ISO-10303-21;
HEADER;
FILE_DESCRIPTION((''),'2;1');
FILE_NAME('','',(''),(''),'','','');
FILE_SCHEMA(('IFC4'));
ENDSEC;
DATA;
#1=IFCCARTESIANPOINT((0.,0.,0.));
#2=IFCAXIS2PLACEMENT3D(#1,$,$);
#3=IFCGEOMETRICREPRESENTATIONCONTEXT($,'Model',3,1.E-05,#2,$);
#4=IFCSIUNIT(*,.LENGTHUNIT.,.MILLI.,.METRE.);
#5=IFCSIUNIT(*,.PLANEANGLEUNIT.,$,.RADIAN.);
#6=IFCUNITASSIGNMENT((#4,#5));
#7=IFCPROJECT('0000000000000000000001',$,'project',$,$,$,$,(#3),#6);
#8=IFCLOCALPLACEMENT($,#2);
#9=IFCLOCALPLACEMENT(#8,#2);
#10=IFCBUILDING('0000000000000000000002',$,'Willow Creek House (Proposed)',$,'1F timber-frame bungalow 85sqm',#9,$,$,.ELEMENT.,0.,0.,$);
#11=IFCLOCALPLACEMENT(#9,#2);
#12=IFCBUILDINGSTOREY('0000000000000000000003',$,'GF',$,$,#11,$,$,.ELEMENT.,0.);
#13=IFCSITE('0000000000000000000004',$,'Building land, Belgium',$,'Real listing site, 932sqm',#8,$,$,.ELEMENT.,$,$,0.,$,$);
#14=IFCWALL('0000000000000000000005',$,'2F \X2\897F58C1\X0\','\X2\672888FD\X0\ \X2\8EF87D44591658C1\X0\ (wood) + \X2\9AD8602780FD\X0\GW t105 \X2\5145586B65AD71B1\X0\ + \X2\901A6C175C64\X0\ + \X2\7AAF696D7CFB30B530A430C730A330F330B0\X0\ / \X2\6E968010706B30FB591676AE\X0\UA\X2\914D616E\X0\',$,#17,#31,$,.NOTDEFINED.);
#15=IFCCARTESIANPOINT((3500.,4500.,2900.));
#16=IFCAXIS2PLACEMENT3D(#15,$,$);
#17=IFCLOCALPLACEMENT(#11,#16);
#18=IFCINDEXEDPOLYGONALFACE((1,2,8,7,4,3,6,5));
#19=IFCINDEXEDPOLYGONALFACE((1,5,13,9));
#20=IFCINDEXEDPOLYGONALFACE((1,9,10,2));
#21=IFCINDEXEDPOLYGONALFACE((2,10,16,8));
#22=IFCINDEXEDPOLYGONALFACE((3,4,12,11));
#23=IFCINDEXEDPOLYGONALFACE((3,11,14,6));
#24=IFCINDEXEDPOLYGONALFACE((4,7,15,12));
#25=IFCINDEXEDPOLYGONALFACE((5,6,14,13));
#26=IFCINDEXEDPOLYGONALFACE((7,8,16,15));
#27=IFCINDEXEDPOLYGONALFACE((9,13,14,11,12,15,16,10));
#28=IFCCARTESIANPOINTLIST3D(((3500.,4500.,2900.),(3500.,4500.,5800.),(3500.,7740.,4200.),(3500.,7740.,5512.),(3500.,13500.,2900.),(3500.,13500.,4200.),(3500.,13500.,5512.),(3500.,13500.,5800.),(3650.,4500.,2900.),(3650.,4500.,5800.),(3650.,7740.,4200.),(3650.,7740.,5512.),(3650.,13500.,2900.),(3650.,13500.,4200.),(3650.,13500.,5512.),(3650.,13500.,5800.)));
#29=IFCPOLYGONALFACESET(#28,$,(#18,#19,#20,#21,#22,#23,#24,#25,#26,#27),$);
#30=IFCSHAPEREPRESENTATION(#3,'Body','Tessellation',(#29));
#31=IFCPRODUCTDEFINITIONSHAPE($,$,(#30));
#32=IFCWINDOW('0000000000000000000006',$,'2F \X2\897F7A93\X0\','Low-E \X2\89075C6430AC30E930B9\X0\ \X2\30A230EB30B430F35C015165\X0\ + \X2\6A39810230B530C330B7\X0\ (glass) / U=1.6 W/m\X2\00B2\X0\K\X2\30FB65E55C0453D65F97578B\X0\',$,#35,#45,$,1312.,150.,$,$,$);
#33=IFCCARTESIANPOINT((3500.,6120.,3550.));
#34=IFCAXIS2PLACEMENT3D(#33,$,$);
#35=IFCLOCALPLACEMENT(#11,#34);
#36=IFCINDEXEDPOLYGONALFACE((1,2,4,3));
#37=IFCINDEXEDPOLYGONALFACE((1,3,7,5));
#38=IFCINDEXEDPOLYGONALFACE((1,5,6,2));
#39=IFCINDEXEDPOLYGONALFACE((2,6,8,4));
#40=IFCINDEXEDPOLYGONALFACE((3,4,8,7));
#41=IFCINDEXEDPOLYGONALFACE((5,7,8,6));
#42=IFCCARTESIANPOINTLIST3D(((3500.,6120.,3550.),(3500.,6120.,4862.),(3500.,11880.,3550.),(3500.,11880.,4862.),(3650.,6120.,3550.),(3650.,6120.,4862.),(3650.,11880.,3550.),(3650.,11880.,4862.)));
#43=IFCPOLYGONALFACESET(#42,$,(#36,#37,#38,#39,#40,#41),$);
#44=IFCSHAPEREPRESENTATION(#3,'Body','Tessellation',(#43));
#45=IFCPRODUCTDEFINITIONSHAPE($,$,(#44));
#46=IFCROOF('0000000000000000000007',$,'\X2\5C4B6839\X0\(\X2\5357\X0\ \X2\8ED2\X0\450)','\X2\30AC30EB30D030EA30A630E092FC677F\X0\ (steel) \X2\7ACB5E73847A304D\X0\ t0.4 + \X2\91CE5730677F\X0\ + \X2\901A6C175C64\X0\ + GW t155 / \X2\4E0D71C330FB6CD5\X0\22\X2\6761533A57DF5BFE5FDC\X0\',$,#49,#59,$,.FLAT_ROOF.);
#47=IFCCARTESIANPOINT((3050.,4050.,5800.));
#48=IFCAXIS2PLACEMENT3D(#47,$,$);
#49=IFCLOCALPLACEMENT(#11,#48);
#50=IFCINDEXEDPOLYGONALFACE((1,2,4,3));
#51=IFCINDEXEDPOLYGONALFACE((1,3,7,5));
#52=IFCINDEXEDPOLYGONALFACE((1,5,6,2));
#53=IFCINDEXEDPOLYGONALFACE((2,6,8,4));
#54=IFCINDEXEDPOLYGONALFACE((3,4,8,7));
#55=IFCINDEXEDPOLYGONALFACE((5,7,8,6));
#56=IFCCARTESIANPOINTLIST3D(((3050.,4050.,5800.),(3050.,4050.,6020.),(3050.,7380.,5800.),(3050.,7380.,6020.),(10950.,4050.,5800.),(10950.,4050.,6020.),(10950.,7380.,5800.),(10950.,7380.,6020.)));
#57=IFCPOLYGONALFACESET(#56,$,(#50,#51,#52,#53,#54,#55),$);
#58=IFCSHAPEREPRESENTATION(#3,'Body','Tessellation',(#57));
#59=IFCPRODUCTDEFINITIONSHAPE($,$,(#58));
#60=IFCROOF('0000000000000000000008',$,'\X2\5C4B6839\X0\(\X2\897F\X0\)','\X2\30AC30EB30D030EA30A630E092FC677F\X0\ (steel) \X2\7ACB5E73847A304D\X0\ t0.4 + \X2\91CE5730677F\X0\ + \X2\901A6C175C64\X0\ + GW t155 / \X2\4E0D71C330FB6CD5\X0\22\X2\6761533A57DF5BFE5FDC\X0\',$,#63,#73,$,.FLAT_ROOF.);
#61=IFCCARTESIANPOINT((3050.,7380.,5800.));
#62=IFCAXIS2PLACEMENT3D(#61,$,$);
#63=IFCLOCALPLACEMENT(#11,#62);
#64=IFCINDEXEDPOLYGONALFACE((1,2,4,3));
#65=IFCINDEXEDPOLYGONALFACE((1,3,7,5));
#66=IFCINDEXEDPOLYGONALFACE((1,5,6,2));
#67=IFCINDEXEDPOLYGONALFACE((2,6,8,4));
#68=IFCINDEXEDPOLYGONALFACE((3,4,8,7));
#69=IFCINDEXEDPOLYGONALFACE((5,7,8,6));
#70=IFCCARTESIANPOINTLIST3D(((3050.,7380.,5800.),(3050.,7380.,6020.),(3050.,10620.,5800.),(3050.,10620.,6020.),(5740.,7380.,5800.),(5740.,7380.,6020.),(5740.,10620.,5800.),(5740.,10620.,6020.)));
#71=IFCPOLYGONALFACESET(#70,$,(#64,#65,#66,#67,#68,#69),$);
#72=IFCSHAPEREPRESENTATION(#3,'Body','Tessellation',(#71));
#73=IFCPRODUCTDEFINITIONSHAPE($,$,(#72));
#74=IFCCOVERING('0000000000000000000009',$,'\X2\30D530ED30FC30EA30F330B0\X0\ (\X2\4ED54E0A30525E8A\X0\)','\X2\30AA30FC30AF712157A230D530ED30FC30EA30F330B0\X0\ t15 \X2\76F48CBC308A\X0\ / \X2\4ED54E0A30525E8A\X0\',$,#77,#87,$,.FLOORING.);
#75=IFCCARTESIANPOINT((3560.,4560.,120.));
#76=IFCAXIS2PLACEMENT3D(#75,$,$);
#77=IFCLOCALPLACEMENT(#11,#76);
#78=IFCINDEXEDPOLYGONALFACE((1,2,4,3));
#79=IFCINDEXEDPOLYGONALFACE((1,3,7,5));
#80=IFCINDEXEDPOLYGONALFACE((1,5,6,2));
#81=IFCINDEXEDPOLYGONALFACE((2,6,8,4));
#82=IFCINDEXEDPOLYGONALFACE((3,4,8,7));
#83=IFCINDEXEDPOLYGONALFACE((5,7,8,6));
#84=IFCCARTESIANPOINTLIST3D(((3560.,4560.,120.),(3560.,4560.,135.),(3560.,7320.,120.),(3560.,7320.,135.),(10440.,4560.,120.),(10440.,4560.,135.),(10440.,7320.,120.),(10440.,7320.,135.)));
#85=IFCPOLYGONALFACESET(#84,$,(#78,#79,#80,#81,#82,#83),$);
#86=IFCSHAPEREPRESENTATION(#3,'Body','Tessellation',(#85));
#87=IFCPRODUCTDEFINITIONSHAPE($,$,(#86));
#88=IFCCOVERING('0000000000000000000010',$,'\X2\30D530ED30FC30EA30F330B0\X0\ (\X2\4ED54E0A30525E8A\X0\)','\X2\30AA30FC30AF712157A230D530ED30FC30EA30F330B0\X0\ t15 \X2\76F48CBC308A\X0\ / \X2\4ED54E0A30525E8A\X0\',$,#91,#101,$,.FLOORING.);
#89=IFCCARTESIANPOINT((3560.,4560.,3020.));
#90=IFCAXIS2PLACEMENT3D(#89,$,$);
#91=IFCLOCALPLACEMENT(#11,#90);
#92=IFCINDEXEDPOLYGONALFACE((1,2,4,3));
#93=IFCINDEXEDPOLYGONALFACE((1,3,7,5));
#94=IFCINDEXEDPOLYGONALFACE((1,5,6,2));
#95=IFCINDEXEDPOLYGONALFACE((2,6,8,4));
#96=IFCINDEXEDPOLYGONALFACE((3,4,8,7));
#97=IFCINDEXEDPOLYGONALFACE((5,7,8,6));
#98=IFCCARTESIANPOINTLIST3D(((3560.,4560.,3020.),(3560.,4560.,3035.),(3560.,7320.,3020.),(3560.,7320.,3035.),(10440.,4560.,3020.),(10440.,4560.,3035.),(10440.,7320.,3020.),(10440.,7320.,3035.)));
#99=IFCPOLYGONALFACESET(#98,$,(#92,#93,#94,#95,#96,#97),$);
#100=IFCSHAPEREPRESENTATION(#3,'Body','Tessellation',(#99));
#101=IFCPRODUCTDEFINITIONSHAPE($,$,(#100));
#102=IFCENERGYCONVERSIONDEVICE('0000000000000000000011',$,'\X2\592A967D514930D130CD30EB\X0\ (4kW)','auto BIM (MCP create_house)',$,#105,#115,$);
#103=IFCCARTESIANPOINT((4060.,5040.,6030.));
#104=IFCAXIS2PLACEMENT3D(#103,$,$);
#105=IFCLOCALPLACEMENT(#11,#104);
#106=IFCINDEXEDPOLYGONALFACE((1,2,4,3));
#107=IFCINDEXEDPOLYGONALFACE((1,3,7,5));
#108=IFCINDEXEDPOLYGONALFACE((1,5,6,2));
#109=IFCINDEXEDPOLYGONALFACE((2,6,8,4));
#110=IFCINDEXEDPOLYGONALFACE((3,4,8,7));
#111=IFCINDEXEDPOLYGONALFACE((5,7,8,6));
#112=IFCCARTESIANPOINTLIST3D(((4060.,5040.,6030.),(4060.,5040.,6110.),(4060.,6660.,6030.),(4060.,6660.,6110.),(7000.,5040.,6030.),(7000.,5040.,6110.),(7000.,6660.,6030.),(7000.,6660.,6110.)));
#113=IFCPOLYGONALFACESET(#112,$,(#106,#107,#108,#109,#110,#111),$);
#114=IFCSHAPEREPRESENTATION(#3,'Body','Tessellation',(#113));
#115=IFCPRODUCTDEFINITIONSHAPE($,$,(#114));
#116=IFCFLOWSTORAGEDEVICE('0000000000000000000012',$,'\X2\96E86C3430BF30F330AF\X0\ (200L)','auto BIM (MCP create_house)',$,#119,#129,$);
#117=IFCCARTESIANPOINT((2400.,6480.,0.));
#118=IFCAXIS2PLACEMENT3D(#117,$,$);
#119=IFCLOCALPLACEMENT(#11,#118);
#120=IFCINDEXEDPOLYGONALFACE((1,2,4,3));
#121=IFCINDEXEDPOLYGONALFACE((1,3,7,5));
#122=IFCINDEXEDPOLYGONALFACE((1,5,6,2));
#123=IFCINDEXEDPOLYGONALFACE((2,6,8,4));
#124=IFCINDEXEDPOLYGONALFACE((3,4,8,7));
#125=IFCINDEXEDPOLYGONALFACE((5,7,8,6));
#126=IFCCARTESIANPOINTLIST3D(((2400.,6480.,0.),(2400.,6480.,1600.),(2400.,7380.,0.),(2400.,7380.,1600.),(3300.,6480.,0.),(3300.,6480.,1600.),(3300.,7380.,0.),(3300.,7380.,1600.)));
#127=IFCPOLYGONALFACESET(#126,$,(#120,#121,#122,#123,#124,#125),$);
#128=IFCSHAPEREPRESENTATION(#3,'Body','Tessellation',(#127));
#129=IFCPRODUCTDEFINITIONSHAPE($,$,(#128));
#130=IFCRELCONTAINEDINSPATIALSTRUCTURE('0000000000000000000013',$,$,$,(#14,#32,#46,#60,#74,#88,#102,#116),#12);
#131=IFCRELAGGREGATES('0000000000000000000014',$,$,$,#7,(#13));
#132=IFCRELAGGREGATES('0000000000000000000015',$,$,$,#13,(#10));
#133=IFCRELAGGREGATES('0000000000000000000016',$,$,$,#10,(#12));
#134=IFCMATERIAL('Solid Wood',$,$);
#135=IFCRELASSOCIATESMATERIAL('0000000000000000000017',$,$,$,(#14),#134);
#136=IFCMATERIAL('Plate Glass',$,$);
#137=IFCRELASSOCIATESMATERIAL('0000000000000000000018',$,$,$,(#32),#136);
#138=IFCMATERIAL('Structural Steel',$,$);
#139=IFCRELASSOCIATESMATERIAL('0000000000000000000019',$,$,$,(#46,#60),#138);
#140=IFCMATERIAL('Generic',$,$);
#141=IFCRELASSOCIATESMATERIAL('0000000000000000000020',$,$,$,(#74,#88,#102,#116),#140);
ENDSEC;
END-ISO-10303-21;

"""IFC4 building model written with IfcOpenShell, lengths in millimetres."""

from ifc_helpers import new_model, si_unit, frame, frame_2d, origin, place, context, project, spatial, rectangle, extrude, material, element, fill, save


model = new_model("IFC4")

# Units and contexts
model_context = context("Model", 3, precision=1e-05, world=origin())
ifc_project = project(units=[si_unit("LENGTHUNIT", "METRE", prefix="MILLI"), si_unit("PLANEANGLEUNIT", "RADIAN")], contexts=[model_context])

# Site, building, storey
site_placement = place(None, origin())
site = spatial("IfcSite", under=ifc_project, at=site_placement, Name="Building land, Belgium", ObjectType="Real listing site, 932sqm", CompositionType="ELEMENT", RefElevation=0.0)
building_placement = place(site_placement, origin())
building = spatial("IfcBuilding", under=site, at=building_placement, Name="Willow Creek House (Proposed)", ObjectType="1F timber-frame bungalow 85sqm", CompositionType="ELEMENT", ElevationOfRefHeight=0.0, ElevationOfTerrain=0.0)
storey_placement = place(building_placement, origin())
storey = spatial("IfcBuildingStorey", under=building, at=storey_placement, Name="GF", CompositionType="ELEMENT", Elevation=0.0)

# Shared definitions
ifc_material_1 = material(Name="Solid Wood")
ifc_material_2 = material(Name="Generic")

# Shared definitions
ifc_material_3 = material(Name="Plate Glass")

# Wall, opening, window
wall_1_placement = place(storey_placement, frame((3500.0, 4500.0, 2900.0)))
wall_1 = element("IfcWall", 1, at=wall_1_placement, inside=storey, material=ifc_material_1, Name="2F 西壁", Description="木製 軸組外壁 (wood) + 高性能GW t105 充填断熱 + 通気層 + 窯業系サイディング / 準耐火・外皮UA配慮", PredefinedType="NOTDEFINED", context=model_context, shape_type="SweptSolid", body=[
    extrude(rectangle(XDim=150.0, YDim=9000.0, at=frame_2d((75.0, 4500.0))), frame((3500.0, 4500.0, 2900.0)), (0.0, 0.0, 1.0), 2900.0),
])
opening_1_placement = place(storey_placement, frame((3500.0, 6120.0, 3550.0)))
opening_1 = element("IfcOpeningElement", 2, at=opening_1_placement, cuts=wall_1, PredefinedType="NOTDEFINED", context=model_context, shape_type="SweptSolid", body=[
    extrude(rectangle(XDim=150.0, YDim=5760.0, at=frame_2d((75.0, 2880.0))), frame((3500.0, 6120.0, 3550.0)), (0.0, 0.0, 1.0), 1312.0),
])
window_1_placement = place(storey_placement, frame((3500.0, 6120.0, 3550.0)))
window_1 = element("IfcWindow", 3, at=window_1_placement, inside=storey, material=ifc_material_3, Name="2F 西窓", Description="Low-E 複層ガラス アルゴン封入 + 樹脂サッシ (glass) / U=1.6 W/m²K・日射取得型", OverallHeight=1312.0, OverallWidth=150.0, context=model_context, shape_type="SweptSolid", body=[
    extrude(rectangle(XDim=150.0, YDim=5760.0, at=frame_2d((75.0, 2880.0))), frame((3500.0, 6120.0, 3550.0)), (0.0, 0.0, 1.0), 1312.0),
])
fill(opening_1, window_1)

# Roofs
ifc_material_4 = material(Name="Structural Steel")
roof_1_placement = place(storey_placement, frame((3050.0, 4050.0, 5800.0)))
element("IfcRoof", 4, at=roof_1_placement, inside=storey, material=ifc_material_4, Name="屋根(南 軒450)", Description="ガルバリウム鋼板 (steel) 立平葺き t0.4 + 野地板 + 通気層 + GW t155 / 不燃・法22条区域対応", PredefinedType="FLAT_ROOF", context=model_context, shape_type="SweptSolid", body=[
    extrude(rectangle(XDim=7900.0, YDim=3330.0, at=frame_2d((3950.0, 1665.0))), frame((3050.0, 4050.0, 5800.0)), (0.0, 0.0, 1.0), 220.0),
])
roof_2_placement = place(storey_placement, frame((3050.0, 7380.0, 5800.0)))
element("IfcRoof", 5, at=roof_2_placement, inside=storey, material=ifc_material_4, Name="屋根(西)", Description="ガルバリウム鋼板 (steel) 立平葺き t0.4 + 野地板 + 通気層 + GW t155 / 不燃・法22条区域対応", PredefinedType="FLAT_ROOF", context=model_context, shape_type="SweptSolid", body=[
    extrude(rectangle(XDim=2690.0, YDim=3240.0, at=frame_2d((1345.0, 1620.0))), frame((3050.0, 7380.0, 5800.0)), (0.0, 0.0, 1.0), 220.0),
])

# Coverings
covering_1_placement = place(storey_placement, frame((3560.0, 4560.0, 120.0)))
element("IfcCovering", 6, at=covering_1_placement, inside=storey, material=ifc_material_2, Name="フローリング (仕上げ床)", Description="オーク無垢フローリング t15 直貼り / 仕上げ床", PredefinedType="FLOORING", context=model_context, shape_type="SweptSolid", body=[
    extrude(rectangle(XDim=6880.0, YDim=2760.0, at=frame_2d((3440.0, 1380.0))), frame((3560.0, 4560.0, 120.0)), (0.0, 0.0, 1.0), 15.0),
])
covering_2_placement = place(storey_placement, frame((3560.0, 4560.0, 3020.0)))
element("IfcCovering", 7, at=covering_2_placement, inside=storey, material=ifc_material_2, Name="フローリング (仕上げ床)", Description="オーク無垢フローリング t15 直貼り / 仕上げ床", PredefinedType="FLOORING", context=model_context, shape_type="SweptSolid", body=[
    extrude(rectangle(XDim=6880.0, YDim=2760.0, at=frame_2d((3440.0, 1380.0))), frame((3560.0, 4560.0, 3020.0)), (0.0, 0.0, 1.0), 15.0),
])

# Energy conversion device
energy_conversion_device_placement = place(storey_placement, frame((4060.0, 5040.0, 6030.0)))
element("IfcEnergyConversionDevice", 8, at=energy_conversion_device_placement, inside=storey, material=ifc_material_2, Name="太陽光パネル (4kW)", Description="auto BIM (MCP create_house)", context=model_context, shape_type="SweptSolid", body=[
    extrude(rectangle(XDim=2940.0, YDim=1620.0, at=frame_2d((1470.0, 810.0))), frame((4060.0, 5040.0, 6030.0)), (0.0, 0.0, 1.0), 80.0),
])

# Flow storage device
flow_storage_device_placement = place(storey_placement, frame((2400.0, 6480.0, 0.0)))
element("IfcFlowStorageDevice", 9, at=flow_storage_device_placement, inside=storey, material=ifc_material_2, Name="雨水タンク (200L)", Description="auto BIM (MCP create_house)", context=model_context, shape_type="SweptSolid", body=[
    extrude(rectangle(XDim=900.0, YDim=900.0, at=frame_2d((450.0, 450.0))), frame((2400.0, 6480.0, 0.0)), (0.0, 0.0, 1.0), 1600.0),
])

save(model, "model.ifc")
